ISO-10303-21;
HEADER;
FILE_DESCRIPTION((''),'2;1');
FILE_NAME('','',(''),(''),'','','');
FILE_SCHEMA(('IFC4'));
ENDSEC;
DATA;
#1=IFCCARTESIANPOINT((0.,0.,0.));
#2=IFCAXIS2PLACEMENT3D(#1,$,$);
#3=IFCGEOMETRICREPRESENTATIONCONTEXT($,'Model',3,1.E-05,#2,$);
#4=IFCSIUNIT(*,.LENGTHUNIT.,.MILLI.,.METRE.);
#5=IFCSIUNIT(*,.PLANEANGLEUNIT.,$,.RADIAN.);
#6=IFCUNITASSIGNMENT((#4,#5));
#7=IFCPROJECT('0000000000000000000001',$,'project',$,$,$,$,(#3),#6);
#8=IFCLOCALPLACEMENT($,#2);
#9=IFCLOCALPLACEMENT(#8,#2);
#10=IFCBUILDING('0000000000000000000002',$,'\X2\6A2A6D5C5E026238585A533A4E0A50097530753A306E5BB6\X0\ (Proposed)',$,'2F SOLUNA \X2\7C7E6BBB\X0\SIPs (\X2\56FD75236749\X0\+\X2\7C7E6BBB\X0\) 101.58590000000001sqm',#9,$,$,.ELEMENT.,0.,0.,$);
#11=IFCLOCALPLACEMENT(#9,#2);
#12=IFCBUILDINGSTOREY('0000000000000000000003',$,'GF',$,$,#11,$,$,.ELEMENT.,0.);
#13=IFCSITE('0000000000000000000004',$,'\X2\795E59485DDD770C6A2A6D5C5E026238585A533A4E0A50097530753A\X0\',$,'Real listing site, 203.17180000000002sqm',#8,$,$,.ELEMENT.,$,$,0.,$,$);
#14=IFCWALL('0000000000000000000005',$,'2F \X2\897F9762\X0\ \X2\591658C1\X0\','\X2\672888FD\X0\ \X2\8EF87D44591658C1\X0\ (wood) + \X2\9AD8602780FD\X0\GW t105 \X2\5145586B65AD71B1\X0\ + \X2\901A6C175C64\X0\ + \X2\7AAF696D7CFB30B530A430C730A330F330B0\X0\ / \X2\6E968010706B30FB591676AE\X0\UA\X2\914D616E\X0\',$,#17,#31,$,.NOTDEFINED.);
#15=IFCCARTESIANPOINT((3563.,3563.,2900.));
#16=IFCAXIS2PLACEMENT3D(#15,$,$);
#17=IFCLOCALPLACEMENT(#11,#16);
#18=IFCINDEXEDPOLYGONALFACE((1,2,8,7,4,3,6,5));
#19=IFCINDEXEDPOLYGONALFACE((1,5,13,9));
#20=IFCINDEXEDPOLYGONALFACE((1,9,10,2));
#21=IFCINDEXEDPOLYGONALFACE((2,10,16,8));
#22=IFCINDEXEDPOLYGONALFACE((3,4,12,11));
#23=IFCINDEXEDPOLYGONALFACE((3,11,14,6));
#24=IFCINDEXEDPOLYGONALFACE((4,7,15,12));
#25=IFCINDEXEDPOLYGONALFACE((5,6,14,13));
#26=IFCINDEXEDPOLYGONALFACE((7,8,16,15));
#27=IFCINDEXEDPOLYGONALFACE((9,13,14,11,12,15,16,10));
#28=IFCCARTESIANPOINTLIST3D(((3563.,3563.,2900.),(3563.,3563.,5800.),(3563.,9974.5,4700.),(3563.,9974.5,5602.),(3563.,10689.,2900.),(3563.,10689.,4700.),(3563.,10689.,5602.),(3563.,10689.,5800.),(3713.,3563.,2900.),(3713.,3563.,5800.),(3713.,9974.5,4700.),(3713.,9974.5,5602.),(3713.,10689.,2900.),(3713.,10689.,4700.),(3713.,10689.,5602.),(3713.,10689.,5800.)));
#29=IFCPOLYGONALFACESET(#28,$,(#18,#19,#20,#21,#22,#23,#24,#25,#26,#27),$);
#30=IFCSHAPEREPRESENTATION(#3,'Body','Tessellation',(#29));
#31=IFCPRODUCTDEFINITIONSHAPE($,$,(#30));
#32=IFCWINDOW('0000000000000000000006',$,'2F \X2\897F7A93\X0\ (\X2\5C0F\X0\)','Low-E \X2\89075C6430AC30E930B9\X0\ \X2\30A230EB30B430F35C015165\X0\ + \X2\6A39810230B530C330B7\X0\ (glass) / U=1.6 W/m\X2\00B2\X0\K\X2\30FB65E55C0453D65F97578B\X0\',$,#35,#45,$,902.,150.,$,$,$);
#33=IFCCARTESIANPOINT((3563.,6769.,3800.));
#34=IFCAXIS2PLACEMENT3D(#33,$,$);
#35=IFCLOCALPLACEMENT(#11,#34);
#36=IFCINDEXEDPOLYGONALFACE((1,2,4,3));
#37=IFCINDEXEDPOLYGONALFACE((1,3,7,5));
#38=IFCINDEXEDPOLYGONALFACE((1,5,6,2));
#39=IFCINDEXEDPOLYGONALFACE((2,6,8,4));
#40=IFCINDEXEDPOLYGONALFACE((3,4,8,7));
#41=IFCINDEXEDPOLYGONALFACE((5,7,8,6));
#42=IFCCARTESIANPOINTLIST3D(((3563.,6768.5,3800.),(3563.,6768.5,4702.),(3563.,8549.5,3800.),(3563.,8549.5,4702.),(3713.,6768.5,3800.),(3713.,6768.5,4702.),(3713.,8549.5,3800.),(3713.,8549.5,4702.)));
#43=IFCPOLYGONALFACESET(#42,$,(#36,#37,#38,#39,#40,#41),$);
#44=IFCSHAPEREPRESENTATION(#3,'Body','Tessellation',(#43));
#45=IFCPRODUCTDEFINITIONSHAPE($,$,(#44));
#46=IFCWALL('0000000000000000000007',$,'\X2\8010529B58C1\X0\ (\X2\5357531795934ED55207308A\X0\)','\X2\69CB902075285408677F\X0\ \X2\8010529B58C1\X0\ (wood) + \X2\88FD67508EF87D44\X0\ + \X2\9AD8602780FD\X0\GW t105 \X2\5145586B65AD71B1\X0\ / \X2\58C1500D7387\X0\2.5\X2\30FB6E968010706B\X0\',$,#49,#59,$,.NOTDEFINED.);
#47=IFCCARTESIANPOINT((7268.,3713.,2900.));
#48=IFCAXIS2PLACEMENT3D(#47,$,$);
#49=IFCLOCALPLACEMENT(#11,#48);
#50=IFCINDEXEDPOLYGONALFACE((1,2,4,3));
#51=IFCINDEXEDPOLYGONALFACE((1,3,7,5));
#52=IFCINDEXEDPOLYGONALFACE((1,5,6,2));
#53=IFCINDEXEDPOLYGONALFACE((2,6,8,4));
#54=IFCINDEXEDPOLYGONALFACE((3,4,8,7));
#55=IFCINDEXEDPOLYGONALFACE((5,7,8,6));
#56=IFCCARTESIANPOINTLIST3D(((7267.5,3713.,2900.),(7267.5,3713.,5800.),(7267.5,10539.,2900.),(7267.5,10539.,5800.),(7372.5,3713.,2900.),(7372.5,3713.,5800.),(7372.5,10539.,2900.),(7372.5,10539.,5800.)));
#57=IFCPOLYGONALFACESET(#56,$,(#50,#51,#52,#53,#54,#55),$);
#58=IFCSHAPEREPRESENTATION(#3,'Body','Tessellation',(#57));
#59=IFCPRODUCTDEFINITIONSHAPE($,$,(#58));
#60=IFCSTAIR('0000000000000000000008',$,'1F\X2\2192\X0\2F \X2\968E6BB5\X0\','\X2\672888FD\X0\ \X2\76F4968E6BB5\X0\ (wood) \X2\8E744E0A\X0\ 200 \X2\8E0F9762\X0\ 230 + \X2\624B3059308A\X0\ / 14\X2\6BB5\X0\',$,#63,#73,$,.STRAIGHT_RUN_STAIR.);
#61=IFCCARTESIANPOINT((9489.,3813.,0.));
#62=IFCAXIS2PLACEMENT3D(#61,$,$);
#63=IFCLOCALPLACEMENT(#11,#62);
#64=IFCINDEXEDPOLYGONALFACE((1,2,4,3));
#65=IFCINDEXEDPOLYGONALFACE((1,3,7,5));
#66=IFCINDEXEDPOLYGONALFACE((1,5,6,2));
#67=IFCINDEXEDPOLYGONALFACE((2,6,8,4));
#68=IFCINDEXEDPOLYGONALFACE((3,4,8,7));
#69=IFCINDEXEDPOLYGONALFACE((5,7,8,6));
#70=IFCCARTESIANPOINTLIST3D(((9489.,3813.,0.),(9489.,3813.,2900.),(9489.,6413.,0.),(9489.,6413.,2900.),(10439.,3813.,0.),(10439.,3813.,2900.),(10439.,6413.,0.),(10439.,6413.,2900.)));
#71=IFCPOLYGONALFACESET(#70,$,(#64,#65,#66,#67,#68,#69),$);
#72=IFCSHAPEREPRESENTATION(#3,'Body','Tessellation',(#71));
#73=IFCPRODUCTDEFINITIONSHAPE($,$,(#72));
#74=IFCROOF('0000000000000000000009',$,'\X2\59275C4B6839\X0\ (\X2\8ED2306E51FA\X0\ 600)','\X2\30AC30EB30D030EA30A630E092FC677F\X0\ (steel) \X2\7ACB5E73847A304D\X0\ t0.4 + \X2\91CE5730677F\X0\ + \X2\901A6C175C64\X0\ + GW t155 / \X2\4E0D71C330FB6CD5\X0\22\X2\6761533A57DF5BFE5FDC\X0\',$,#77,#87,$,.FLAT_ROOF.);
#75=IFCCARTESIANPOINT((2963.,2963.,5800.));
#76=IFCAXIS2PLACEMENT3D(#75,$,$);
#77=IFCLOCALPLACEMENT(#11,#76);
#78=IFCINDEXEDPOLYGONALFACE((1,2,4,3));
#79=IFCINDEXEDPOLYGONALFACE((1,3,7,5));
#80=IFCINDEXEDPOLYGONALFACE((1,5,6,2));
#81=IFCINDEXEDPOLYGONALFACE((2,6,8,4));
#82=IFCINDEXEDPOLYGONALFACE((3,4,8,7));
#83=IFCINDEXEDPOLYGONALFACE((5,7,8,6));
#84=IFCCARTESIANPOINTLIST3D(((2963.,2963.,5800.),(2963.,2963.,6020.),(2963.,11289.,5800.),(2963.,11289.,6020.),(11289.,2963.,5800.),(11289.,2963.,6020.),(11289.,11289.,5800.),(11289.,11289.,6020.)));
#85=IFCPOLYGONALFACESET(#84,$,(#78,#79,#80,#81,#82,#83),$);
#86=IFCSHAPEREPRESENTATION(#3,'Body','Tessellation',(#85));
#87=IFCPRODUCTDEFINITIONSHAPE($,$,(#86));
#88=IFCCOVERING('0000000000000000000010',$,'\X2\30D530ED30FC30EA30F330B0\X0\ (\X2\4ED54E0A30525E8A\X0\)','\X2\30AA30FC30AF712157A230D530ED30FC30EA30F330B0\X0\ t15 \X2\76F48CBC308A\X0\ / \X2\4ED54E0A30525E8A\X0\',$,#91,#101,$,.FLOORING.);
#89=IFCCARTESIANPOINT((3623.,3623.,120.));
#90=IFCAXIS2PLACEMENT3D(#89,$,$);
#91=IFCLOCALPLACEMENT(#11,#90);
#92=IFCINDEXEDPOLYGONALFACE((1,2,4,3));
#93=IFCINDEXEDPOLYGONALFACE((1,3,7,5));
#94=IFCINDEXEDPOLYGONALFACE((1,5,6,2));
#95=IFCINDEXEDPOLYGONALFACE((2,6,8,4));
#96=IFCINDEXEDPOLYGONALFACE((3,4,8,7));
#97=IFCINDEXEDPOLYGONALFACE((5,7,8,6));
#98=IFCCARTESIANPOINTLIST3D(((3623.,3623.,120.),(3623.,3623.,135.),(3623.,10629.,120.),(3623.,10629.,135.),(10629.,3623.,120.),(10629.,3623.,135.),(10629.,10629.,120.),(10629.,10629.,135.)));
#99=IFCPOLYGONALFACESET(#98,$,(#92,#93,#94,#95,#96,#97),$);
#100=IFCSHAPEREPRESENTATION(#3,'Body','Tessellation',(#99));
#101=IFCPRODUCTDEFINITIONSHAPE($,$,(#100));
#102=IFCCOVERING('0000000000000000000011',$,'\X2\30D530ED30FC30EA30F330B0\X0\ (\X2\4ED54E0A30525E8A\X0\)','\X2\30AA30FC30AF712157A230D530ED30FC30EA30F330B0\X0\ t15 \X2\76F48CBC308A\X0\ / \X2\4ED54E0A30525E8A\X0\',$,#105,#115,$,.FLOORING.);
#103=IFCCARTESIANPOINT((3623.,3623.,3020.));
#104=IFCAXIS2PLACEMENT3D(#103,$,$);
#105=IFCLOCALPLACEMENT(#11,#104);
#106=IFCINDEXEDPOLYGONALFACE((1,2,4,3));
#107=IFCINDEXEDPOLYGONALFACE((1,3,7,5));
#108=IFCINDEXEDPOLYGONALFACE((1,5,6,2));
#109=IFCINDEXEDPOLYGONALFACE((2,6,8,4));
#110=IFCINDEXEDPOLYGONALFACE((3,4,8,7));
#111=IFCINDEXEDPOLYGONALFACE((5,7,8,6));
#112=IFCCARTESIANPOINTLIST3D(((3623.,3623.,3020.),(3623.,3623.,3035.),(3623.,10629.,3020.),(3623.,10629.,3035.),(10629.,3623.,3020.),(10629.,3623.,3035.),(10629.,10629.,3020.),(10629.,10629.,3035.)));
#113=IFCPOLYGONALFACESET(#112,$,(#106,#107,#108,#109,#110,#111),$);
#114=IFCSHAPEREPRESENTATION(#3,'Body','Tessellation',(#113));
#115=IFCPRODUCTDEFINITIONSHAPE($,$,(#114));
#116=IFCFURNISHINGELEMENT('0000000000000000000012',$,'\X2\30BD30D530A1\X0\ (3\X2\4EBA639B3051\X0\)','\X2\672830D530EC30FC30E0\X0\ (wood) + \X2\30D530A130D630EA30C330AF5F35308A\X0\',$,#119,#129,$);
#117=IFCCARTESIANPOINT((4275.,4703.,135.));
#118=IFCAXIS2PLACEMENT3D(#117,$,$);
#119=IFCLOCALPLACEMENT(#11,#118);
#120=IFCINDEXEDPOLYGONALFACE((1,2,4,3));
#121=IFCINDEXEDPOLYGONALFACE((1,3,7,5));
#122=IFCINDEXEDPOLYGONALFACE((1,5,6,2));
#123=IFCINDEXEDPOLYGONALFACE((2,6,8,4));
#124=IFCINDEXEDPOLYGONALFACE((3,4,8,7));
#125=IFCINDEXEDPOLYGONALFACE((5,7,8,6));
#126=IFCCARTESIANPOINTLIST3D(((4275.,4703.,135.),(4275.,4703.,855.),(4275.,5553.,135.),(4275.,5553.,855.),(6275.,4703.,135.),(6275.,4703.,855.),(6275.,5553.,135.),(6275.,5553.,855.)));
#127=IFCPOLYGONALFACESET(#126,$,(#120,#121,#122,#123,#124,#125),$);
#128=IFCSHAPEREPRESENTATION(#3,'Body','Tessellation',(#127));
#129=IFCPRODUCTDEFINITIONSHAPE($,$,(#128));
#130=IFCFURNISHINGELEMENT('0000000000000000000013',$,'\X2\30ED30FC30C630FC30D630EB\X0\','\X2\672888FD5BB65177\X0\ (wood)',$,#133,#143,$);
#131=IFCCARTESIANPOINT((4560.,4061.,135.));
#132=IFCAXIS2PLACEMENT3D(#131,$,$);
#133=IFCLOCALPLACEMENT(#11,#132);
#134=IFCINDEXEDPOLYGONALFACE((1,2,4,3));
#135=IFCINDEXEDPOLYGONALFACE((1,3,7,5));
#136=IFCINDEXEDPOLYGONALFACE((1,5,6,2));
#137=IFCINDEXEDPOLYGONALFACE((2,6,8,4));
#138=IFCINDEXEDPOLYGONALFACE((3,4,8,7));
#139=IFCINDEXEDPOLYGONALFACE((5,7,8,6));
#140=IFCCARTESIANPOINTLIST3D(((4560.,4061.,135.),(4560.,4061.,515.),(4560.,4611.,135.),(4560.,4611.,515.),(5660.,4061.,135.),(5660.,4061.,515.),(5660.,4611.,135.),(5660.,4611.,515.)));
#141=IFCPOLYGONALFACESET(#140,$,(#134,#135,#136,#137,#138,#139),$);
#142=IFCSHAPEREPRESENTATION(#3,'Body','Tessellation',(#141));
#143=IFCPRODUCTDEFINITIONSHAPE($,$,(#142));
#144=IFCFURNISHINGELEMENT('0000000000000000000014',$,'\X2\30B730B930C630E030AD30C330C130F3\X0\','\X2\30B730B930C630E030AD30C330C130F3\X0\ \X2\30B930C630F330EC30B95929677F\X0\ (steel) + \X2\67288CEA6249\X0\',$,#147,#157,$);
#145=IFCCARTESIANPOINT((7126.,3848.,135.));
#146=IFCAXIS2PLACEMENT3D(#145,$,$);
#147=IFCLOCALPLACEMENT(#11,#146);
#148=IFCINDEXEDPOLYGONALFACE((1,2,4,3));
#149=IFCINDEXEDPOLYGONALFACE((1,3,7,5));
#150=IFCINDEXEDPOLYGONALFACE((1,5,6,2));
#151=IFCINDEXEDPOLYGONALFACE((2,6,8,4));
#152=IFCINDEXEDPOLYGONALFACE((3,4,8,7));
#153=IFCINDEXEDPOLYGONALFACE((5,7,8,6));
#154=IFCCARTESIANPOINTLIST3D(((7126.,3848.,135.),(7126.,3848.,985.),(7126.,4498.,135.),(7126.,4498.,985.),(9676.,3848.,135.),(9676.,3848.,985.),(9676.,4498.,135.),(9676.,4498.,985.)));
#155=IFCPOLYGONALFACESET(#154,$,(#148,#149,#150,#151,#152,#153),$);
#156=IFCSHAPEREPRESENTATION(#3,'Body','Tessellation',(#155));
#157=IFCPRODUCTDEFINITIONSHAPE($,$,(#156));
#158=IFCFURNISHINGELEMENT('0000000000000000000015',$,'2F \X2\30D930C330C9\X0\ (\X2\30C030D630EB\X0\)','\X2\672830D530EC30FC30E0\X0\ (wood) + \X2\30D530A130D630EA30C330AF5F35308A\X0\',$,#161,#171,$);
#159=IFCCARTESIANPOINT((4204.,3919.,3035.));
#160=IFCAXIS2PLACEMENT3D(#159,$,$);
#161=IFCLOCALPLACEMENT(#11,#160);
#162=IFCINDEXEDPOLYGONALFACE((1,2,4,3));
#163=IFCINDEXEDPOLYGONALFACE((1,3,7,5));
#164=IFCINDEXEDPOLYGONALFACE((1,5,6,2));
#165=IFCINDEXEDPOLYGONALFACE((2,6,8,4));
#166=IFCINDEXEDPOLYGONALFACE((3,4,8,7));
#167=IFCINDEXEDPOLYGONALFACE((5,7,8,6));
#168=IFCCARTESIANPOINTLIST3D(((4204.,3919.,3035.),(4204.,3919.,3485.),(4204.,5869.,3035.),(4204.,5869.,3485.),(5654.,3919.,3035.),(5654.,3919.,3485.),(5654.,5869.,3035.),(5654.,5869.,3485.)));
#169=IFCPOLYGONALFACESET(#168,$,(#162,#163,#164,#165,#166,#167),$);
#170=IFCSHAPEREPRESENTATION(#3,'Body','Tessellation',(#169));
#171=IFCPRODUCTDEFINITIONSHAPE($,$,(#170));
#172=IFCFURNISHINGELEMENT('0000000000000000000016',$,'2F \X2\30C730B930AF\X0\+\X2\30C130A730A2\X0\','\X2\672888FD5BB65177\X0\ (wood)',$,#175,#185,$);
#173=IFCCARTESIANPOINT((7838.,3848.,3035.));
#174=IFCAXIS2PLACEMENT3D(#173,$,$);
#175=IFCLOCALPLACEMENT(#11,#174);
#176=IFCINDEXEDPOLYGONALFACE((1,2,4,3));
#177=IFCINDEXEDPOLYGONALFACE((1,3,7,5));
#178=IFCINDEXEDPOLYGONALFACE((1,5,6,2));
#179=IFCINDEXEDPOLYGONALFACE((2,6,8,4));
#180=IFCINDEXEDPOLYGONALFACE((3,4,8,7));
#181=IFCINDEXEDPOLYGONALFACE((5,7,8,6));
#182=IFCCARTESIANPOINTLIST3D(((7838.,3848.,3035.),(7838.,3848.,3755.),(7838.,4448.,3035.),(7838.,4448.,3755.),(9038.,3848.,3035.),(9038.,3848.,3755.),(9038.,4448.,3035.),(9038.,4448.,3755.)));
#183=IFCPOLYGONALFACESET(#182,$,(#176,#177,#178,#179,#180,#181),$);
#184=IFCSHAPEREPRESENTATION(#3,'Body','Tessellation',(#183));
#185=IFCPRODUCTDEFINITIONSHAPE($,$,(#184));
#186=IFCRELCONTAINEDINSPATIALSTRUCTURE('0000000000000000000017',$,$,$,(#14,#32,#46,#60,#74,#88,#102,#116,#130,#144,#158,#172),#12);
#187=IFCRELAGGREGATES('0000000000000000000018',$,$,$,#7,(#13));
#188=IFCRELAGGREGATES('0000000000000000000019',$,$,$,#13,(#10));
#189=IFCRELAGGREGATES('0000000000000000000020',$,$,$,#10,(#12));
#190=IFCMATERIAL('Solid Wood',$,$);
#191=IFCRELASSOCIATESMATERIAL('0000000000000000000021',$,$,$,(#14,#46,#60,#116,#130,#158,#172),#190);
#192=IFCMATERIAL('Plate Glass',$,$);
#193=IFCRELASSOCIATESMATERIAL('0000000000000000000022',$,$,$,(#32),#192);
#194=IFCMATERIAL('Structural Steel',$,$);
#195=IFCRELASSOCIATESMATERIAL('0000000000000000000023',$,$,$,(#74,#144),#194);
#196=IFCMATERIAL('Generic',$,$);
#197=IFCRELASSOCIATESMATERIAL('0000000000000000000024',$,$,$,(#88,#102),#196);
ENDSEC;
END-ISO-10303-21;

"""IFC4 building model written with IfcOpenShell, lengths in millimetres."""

from ifc_helpers import new_model, si_unit, frame, frame_2d, origin, place, context, project, spatial, rectangle, extrude, material, element, fill, save


model = new_model("IFC4")

# Units and contexts
model_context = context("Model", 3, precision=1e-05, world=origin())
ifc_project = project(units=[si_unit("LENGTHUNIT", "METRE", prefix="MILLI"), si_unit("PLANEANGLEUNIT", "RADIAN")], contexts=[model_context])

# Site, building, storey
site_placement = place(None, origin())
site = spatial("IfcSite", under=ifc_project, at=site_placement, Name="神奈川県横浜市戸塚区上倉田町", ObjectType="Real listing site, 203.17180000000002sqm", CompositionType="ELEMENT", RefElevation=0.0)
building_placement = place(site_placement, origin())
building = spatial("IfcBuilding", under=site, at=building_placement, Name="横浜市戸塚区上倉田町の家 (Proposed)", ObjectType="2F SOLUNA 籾殻SIPs (国産杉+籾殻) 101.58590000000001sqm", CompositionType="ELEMENT", ElevationOfRefHeight=0.0, ElevationOfTerrain=0.0)
storey_placement = place(building_placement, origin())
storey = spatial("IfcBuildingStorey", under=building, at=storey_placement, Name="GF", CompositionType="ELEMENT", Elevation=0.0)

# Shared definitions
ifc_material_1 = material(Name="Solid Wood")

# Shared definitions
ifc_material_2 = material(Name="Plate Glass")

# Wall, opening, window
wall_1_placement = place(storey_placement, frame((3563.0, 3563.0, 2900.0)))
wall_1 = element("IfcWall", 1, at=wall_1_placement, inside=storey, material=ifc_material_1, Name="2F 西面 外壁", Description="木製 軸組外壁 (wood) + 高性能GW t105 充填断熱 + 通気層 + 窯業系サイディング / 準耐火・外皮UA配慮", PredefinedType="NOTDEFINED", context=model_context, shape_type="SweptSolid", body=[
    extrude(rectangle(XDim=150.0, YDim=7126.0, at=frame_2d((75.0, 3563.0))), frame((3563.0, 3563.0, 2900.0)), (0.0, 0.0, 1.0), 2900.0),
])
opening_1_placement = place(storey_placement, frame((3563.0, 6769.0, 3800.0)))
opening_1 = element("IfcOpeningElement", 2, at=opening_1_placement, cuts=wall_1, PredefinedType="NOTDEFINED", context=model_context, shape_type="SweptSolid", body=[
    extrude(rectangle(XDim=150.0, YDim=1781.0, at=frame_2d((75.0, 890.0))), frame((3563.0, 6769.0, 3800.0)), (0.0, 0.0, 1.0), 902.0),
])
window_1_placement = place(storey_placement, frame((3563.0, 6769.0, 3800.0)))
window_1 = element("IfcWindow", 3, at=window_1_placement, inside=storey, material=ifc_material_2, Name="2F 西窓 (小)", Description="Low-E 複層ガラス アルゴン封入 + 樹脂サッシ (glass) / U=1.6 W/m²K・日射取得型", OverallHeight=902.0, OverallWidth=150.0, context=model_context, shape_type="SweptSolid", body=[
    extrude(rectangle(XDim=150.0, YDim=1781.0, at=frame_2d((75.0, 890.0))), frame((3563.0, 6769.0, 3800.0)), (0.0, 0.0, 1.0), 902.0),
])
fill(opening_1, window_1)

# Wall
wall_2_placement = place(storey_placement, frame((7268.0, 3713.0, 2900.0)))
element("IfcWall", 4, at=wall_2_placement, inside=storey, material=ifc_material_1, Name="耐力壁 (南北間仕切り)", Description="構造用合板 耐力壁 (wood) + 製材軸組 + 高性能GW t105 充填断熱 / 壁倍率2.5・準耐火", PredefinedType="NOTDEFINED", context=model_context, shape_type="SweptSolid", body=[
    extrude(rectangle(XDim=105.0, YDim=6826.0, at=frame_2d((52.0, 3413.0))), frame((7268.0, 3713.0, 2900.0)), (0.0, 0.0, 1.0), 2900.0),
])

# Stair
stair_placement = place(storey_placement, frame((9489.0, 3813.0, 0.0)))
element("IfcStair", 5, at=stair_placement, inside=storey, material=ifc_material_1, Name="1F→2F 階段", Description="木製 直階段 (wood) 蹴上 200 踏面 230 + 手すり / 14段", PredefinedType="STRAIGHT_RUN_STAIR", context=model_context, shape_type="SweptSolid", body=[
    extrude(rectangle(XDim=950.0, YDim=2600.0, at=frame_2d((475.0, 1300.0))), frame((9489.0, 3813.0, 0.0)), (0.0, 0.0, 1.0), 2900.0),
])

# Roof
ifc_material_3 = material(Name="Structural Steel")
roof_placement = place(storey_placement, frame((2963.0, 2963.0, 5800.0)))
element("IfcRoof", 6, at=roof_placement, inside=storey, material=ifc_material_3, Name="大屋根 (軒の出 600)", Description="ガルバリウム鋼板 (steel) 立平葺き t0.4 + 野地板 + 通気層 + GW t155 / 不燃・法22条区域対応", PredefinedType="FLAT_ROOF", context=model_context, shape_type="SweptSolid", body=[
    extrude(rectangle(XDim=8326.0, YDim=8326.0, at=frame_2d((4163.0, 4163.0))), frame((2963.0, 2963.0, 5800.0)), (0.0, 0.0, 1.0), 220.0),
])

# Coverings
ifc_material_4 = material(Name="Generic")
covering_1_placement = place(storey_placement, frame((3623.0, 3623.0, 120.0)))
element("IfcCovering", 7, at=covering_1_placement, inside=storey, material=ifc_material_4, Name="フローリング (仕上げ床)", Description="オーク無垢フローリング t15 直貼り / 仕上げ床", PredefinedType="FLOORING", context=model_context, shape_type="SweptSolid", body=[
    extrude(rectangle(XDim=7006.0, YDim=7006.0, at=frame_2d((3503.0, 3503.0))), frame((3623.0, 3623.0, 120.0)), (0.0, 0.0, 1.0), 15.0),
])
covering_2_placement = place(storey_placement, frame((3623.0, 3623.0, 3020.0)))
element("IfcCovering", 8, at=covering_2_placement, inside=storey, material=ifc_material_4, Name="フローリング (仕上げ床)", Description="オーク無垢フローリング t15 直貼り / 仕上げ床", PredefinedType="FLOORING", context=model_context, shape_type="SweptSolid", body=[
    extrude(rectangle(XDim=7006.0, YDim=7006.0, at=frame_2d((3503.0, 3503.0))), frame((3623.0, 3623.0, 3020.0)), (0.0, 0.0, 1.0), 15.0),
])

# Furnishing elements
furnishing_1_placement = place(storey_placement, frame((4275.0, 4703.0, 135.0)))
element("IfcFurnishingElement", 9, at=furnishing_1_placement, inside=storey, material=ifc_material_1, Name="ソファ (3人掛け)", Description="木フレーム (wood) + ファブリック張り", context=model_context, shape_type="SweptSolid", body=[
    extrude(rectangle(XDim=2000.0, YDim=850.0, at=frame_2d((1000.0, 425.0))), frame((4275.0, 4703.0, 135.0)), (0.0, 0.0, 1.0), 720.0),
])
furnishing_2_placement = place(storey_placement, frame((4560.0, 4061.0, 135.0)))
element("IfcFurnishingElement", 10, at=furnishing_2_placement, inside=storey, material=ifc_material_1, Name="ローテーブル", Description="木製家具 (wood)", context=model_context, shape_type="SweptSolid", body=[
    extrude(rectangle(XDim=1100.0, YDim=550.0, at=frame_2d((550.0, 275.0))), frame((4560.0, 4061.0, 135.0)), (0.0, 0.0, 1.0), 380.0),
])
furnishing_3_placement = place(storey_placement, frame((7126.0, 3848.0, 135.0)))
element("IfcFurnishingElement", 11, at=furnishing_3_placement, inside=storey, material=ifc_material_3, Name="システムキッチン", Description="システムキッチン ステンレス天板 (steel) + 木質扉", context=model_context, shape_type="SweptSolid", body=[
    extrude(rectangle(XDim=2550.0, YDim=650.0, at=frame_2d((1275.0, 325.0))), frame((7126.0, 3848.0, 135.0)), (0.0, 0.0, 1.0), 850.0),
])
furnishing_4_placement = place(storey_placement, frame((4204.0, 3919.0, 3035.0)))
element("IfcFurnishingElement", 12, at=furnishing_4_placement, inside=storey, material=ifc_material_1, Name="2F ベッド (ダブル)", Description="木フレーム (wood) + ファブリック張り", context=model_context, shape_type="SweptSolid", body=[
    extrude(rectangle(XDim=1450.0, YDim=1950.0, at=frame_2d((725.0, 975.0))), frame((4204.0, 3919.0, 3035.0)), (0.0, 0.0, 1.0), 450.0),
])
furnishing_5_placement = place(storey_placement, frame((7838.0, 3848.0, 3035.0)))
element("IfcFurnishingElement", 13, at=furnishing_5_placement, inside=storey, material=ifc_material_1, Name="2F デスク+チェア", Description="木製家具 (wood)", context=model_context, shape_type="SweptSolid", body=[
    extrude(rectangle(XDim=1200.0, YDim=600.0, at=frame_2d((600.0, 300.0))), frame((7838.0, 3848.0, 3035.0)), (0.0, 0.0, 1.0), 720.0),
])

save(model, "model.ifc")
